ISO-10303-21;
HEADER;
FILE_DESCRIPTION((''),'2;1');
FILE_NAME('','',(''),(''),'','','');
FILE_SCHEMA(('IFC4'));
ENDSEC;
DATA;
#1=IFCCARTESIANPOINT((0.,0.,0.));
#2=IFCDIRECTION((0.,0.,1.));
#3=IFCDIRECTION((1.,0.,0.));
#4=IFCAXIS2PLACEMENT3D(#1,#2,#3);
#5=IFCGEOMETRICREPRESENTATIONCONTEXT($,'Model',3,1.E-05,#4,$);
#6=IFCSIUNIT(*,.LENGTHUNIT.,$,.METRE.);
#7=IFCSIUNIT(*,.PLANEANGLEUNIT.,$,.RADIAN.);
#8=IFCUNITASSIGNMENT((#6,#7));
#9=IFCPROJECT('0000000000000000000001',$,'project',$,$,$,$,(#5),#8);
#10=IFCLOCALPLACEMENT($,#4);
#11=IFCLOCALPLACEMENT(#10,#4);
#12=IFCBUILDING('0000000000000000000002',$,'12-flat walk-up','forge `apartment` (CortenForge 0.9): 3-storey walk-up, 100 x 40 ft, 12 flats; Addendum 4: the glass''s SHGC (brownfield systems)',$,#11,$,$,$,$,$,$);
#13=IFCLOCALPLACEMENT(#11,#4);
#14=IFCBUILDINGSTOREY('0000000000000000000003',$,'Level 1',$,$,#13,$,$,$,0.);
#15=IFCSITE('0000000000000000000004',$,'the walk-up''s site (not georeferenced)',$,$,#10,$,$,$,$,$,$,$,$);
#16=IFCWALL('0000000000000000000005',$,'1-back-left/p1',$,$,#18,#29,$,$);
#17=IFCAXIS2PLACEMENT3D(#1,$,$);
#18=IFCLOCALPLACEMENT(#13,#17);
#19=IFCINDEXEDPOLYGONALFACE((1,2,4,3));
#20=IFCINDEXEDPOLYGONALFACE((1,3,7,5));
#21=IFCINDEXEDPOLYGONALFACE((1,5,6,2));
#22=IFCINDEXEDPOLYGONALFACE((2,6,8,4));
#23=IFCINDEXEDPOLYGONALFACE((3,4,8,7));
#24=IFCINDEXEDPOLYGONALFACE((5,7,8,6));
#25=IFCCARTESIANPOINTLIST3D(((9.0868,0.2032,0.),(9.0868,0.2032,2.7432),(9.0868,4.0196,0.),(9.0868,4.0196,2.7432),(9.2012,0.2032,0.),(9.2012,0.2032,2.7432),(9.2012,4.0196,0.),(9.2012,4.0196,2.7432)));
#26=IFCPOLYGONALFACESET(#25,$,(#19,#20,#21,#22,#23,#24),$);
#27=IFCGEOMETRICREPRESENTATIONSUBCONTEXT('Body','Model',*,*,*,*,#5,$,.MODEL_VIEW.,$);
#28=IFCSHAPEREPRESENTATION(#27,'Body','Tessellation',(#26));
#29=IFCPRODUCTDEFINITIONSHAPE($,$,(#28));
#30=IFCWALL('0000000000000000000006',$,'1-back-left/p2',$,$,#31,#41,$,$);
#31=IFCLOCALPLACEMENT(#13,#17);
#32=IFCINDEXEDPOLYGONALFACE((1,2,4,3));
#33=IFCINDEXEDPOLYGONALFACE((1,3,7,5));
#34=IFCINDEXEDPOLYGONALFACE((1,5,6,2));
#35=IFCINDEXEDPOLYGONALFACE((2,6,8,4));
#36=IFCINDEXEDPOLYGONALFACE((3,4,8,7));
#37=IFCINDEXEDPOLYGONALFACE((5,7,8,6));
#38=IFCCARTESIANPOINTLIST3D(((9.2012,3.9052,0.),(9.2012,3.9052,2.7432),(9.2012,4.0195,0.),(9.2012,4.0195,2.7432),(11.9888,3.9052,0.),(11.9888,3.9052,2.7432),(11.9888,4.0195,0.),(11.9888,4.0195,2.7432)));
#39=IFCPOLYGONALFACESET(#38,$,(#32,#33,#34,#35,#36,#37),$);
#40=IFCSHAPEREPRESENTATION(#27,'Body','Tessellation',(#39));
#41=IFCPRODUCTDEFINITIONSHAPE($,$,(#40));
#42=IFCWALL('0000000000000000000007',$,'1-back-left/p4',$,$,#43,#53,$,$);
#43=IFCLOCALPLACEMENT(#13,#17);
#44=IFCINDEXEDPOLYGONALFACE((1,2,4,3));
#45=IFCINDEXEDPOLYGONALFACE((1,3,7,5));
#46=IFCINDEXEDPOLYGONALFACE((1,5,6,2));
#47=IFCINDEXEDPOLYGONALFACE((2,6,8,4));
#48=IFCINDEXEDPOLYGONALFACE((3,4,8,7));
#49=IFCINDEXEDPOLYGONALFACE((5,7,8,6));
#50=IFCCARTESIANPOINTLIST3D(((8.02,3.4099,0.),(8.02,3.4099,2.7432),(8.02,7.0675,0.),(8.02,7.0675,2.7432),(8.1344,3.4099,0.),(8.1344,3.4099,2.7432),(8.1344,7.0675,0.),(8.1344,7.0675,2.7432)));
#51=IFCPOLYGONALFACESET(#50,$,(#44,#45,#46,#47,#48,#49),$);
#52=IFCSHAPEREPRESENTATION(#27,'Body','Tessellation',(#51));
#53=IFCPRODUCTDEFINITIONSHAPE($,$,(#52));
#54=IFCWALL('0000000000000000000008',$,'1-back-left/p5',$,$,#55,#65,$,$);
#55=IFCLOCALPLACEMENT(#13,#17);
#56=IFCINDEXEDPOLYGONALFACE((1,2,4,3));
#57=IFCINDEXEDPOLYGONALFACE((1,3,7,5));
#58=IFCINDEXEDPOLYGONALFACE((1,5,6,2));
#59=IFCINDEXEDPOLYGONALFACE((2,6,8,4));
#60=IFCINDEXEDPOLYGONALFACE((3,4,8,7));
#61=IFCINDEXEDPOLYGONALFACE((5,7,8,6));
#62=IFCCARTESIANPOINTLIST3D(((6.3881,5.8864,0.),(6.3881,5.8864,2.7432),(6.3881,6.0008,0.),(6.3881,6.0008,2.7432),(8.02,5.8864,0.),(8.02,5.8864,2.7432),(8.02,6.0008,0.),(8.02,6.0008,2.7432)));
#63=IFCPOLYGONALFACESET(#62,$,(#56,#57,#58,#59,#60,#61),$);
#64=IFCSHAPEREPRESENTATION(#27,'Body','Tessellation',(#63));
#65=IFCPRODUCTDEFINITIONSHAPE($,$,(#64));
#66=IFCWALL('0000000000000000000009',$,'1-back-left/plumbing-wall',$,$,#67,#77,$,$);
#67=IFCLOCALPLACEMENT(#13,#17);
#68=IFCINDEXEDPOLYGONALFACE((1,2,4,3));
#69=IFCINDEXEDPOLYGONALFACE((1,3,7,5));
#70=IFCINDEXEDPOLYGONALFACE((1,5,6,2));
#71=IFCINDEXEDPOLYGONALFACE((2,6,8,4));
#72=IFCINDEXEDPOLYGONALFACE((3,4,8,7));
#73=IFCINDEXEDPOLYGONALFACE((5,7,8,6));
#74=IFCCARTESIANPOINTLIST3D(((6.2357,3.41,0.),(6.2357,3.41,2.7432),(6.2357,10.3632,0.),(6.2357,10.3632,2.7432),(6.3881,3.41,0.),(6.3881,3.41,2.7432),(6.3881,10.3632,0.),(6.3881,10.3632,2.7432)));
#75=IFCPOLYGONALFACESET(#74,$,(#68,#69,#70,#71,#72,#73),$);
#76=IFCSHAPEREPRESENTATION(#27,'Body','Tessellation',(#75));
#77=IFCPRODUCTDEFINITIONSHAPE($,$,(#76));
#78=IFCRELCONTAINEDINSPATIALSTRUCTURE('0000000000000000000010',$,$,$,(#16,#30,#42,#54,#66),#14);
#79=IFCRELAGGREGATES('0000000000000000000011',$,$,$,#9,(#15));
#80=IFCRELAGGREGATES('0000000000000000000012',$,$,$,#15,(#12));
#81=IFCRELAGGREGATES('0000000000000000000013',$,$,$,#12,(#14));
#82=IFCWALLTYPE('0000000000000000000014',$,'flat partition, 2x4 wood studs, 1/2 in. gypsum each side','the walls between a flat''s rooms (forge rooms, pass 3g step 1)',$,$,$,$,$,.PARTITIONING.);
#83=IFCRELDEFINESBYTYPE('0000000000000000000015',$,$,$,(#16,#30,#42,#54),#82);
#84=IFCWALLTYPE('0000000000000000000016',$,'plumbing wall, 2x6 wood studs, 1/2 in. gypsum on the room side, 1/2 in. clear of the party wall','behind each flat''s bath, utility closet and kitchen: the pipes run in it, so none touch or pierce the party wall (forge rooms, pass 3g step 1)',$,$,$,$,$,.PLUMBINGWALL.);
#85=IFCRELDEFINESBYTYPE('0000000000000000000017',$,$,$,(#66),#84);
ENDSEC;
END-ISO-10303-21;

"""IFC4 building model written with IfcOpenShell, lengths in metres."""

from ifc_helpers import new_model, si_unit, frame, frame_2d, origin, origin_with_axes, place, context, subcontext, project, spatial, rectangle, extrude, type_object, element, save


model = new_model("IFC4")

# Units and contexts
model_context = context("Model", 3, precision=1e-05, world=origin_with_axes())
body_context = subcontext(model_context, "Body", "Model", "MODEL_VIEW")
ifc_project = project(units=[si_unit("LENGTHUNIT", "METRE"), si_unit("PLANEANGLEUNIT", "RADIAN")], contexts=[model_context])

# Site, building, storey
site_placement = place(None, origin_with_axes())
site = spatial("IfcSite", under=ifc_project, at=site_placement, Name="the walk-up's site (not georeferenced)")
building_placement = place(site_placement, origin_with_axes())
building = spatial("IfcBuilding", under=site, at=building_placement, Name="12-flat walk-up", Description="forge `apartment` (CortenForge 0.9): 3-storey walk-up, 100 x 40 ft, 12 flats; Addendum 4: the glass's SHGC (brownfield systems)")
storey_placement = place(building_placement, origin_with_axes())
storey = spatial("IfcBuildingStorey", under=building, at=storey_placement, Name="Level 1", Elevation=0.0)

# Walls
wall_type_1 = type_object("IfcWallType", Name="flat partition, 2x4 wood studs, 1/2 in. gypsum each side", Description="the walls between a flat's rooms (forge rooms, pass 3g step 1)", PredefinedType="PARTITIONING")
wall_1_placement = place(storey_placement, frame((9.0869, 0.2032, 0.0), z_axis=(0.0, 0.0, 1.0), x_axis=(1.0, 0.0, 0.0)))
element("IfcWall", 1, at=wall_1_placement, inside=storey, type_object=wall_type_1, Name="1-back-left/p1", context=body_context, shape_type="SweptSolid", body=[
    extrude(rectangle(XDim=0.1143, YDim=3.8163, at=frame_2d((0.0572, 1.9082))), origin(), (0.0, 0.0, 1.0), 2.7432),
])
wall_2_placement = place(storey_placement, frame((9.2012, 3.9052, 0.0), z_axis=(0.0, 0.0, 1.0), x_axis=(1.0, 0.0, 0.0)))
element("IfcWall", 2, at=wall_2_placement, inside=storey, type_object=wall_type_1, Name="1-back-left/p2", context=body_context, shape_type="SweptSolid", body=[
    extrude(rectangle(XDim=2.7876, YDim=0.1143, at=frame_2d((1.3938, 0.0571))), origin(), (0.0, 0.0, 1.0), 2.7432),
])
wall_3_placement = place(storey_placement, frame((8.02, 3.4099, 0.0), z_axis=(0.0, 0.0, 1.0), x_axis=(1.0, 0.0, 0.0)))
element("IfcWall", 3, at=wall_3_placement, inside=storey, type_object=wall_type_1, Name="1-back-left/p4", context=body_context, shape_type="SweptSolid", body=[
    extrude(rectangle(XDim=0.1143, YDim=3.6576, at=frame_2d((0.0572, 1.8288))), origin(), (0.0, 0.0, 1.0), 2.7432),
])
wall_4_placement = place(storey_placement, frame((6.3881, 5.8864, 0.0), z_axis=(0.0, 0.0, 1.0), x_axis=(1.0, 0.0, 0.0)))
element("IfcWall", 4, at=wall_4_placement, inside=storey, type_object=wall_type_1, Name="1-back-left/p5", context=body_context, shape_type="SweptSolid", body=[
    extrude(rectangle(XDim=1.6319, YDim=0.1143, at=frame_2d((0.816, 0.0572))), origin(), (0.0, 0.0, 1.0), 2.7432),
])
wall_type_2 = type_object("IfcWallType", Name="plumbing wall, 2x6 wood studs, 1/2 in. gypsum on the room side, 1/2 in. clear of the party wall", Description="behind each flat's bath, utility closet and kitchen: the pipes run in it, so none touch or pierce the party wall (forge rooms, pass 3g step 1)", PredefinedType="PLUMBINGWALL")
wall_5_placement = place(storey_placement, frame((6.2357, 3.41, 0.0), z_axis=(0.0, 0.0, 1.0), x_axis=(1.0, 0.0, 0.0)))
element("IfcWall", 5, at=wall_5_placement, inside=storey, type_object=wall_type_2, Name="1-back-left/plumbing-wall", context=body_context, shape_type="SweptSolid", body=[
    extrude(rectangle(XDim=0.1524, YDim=6.9533, at=frame_2d((0.0762, 3.4766))), origin(), (0.0, 0.0, 1.0), 2.7432),
])

save(model, "model.ifc")
